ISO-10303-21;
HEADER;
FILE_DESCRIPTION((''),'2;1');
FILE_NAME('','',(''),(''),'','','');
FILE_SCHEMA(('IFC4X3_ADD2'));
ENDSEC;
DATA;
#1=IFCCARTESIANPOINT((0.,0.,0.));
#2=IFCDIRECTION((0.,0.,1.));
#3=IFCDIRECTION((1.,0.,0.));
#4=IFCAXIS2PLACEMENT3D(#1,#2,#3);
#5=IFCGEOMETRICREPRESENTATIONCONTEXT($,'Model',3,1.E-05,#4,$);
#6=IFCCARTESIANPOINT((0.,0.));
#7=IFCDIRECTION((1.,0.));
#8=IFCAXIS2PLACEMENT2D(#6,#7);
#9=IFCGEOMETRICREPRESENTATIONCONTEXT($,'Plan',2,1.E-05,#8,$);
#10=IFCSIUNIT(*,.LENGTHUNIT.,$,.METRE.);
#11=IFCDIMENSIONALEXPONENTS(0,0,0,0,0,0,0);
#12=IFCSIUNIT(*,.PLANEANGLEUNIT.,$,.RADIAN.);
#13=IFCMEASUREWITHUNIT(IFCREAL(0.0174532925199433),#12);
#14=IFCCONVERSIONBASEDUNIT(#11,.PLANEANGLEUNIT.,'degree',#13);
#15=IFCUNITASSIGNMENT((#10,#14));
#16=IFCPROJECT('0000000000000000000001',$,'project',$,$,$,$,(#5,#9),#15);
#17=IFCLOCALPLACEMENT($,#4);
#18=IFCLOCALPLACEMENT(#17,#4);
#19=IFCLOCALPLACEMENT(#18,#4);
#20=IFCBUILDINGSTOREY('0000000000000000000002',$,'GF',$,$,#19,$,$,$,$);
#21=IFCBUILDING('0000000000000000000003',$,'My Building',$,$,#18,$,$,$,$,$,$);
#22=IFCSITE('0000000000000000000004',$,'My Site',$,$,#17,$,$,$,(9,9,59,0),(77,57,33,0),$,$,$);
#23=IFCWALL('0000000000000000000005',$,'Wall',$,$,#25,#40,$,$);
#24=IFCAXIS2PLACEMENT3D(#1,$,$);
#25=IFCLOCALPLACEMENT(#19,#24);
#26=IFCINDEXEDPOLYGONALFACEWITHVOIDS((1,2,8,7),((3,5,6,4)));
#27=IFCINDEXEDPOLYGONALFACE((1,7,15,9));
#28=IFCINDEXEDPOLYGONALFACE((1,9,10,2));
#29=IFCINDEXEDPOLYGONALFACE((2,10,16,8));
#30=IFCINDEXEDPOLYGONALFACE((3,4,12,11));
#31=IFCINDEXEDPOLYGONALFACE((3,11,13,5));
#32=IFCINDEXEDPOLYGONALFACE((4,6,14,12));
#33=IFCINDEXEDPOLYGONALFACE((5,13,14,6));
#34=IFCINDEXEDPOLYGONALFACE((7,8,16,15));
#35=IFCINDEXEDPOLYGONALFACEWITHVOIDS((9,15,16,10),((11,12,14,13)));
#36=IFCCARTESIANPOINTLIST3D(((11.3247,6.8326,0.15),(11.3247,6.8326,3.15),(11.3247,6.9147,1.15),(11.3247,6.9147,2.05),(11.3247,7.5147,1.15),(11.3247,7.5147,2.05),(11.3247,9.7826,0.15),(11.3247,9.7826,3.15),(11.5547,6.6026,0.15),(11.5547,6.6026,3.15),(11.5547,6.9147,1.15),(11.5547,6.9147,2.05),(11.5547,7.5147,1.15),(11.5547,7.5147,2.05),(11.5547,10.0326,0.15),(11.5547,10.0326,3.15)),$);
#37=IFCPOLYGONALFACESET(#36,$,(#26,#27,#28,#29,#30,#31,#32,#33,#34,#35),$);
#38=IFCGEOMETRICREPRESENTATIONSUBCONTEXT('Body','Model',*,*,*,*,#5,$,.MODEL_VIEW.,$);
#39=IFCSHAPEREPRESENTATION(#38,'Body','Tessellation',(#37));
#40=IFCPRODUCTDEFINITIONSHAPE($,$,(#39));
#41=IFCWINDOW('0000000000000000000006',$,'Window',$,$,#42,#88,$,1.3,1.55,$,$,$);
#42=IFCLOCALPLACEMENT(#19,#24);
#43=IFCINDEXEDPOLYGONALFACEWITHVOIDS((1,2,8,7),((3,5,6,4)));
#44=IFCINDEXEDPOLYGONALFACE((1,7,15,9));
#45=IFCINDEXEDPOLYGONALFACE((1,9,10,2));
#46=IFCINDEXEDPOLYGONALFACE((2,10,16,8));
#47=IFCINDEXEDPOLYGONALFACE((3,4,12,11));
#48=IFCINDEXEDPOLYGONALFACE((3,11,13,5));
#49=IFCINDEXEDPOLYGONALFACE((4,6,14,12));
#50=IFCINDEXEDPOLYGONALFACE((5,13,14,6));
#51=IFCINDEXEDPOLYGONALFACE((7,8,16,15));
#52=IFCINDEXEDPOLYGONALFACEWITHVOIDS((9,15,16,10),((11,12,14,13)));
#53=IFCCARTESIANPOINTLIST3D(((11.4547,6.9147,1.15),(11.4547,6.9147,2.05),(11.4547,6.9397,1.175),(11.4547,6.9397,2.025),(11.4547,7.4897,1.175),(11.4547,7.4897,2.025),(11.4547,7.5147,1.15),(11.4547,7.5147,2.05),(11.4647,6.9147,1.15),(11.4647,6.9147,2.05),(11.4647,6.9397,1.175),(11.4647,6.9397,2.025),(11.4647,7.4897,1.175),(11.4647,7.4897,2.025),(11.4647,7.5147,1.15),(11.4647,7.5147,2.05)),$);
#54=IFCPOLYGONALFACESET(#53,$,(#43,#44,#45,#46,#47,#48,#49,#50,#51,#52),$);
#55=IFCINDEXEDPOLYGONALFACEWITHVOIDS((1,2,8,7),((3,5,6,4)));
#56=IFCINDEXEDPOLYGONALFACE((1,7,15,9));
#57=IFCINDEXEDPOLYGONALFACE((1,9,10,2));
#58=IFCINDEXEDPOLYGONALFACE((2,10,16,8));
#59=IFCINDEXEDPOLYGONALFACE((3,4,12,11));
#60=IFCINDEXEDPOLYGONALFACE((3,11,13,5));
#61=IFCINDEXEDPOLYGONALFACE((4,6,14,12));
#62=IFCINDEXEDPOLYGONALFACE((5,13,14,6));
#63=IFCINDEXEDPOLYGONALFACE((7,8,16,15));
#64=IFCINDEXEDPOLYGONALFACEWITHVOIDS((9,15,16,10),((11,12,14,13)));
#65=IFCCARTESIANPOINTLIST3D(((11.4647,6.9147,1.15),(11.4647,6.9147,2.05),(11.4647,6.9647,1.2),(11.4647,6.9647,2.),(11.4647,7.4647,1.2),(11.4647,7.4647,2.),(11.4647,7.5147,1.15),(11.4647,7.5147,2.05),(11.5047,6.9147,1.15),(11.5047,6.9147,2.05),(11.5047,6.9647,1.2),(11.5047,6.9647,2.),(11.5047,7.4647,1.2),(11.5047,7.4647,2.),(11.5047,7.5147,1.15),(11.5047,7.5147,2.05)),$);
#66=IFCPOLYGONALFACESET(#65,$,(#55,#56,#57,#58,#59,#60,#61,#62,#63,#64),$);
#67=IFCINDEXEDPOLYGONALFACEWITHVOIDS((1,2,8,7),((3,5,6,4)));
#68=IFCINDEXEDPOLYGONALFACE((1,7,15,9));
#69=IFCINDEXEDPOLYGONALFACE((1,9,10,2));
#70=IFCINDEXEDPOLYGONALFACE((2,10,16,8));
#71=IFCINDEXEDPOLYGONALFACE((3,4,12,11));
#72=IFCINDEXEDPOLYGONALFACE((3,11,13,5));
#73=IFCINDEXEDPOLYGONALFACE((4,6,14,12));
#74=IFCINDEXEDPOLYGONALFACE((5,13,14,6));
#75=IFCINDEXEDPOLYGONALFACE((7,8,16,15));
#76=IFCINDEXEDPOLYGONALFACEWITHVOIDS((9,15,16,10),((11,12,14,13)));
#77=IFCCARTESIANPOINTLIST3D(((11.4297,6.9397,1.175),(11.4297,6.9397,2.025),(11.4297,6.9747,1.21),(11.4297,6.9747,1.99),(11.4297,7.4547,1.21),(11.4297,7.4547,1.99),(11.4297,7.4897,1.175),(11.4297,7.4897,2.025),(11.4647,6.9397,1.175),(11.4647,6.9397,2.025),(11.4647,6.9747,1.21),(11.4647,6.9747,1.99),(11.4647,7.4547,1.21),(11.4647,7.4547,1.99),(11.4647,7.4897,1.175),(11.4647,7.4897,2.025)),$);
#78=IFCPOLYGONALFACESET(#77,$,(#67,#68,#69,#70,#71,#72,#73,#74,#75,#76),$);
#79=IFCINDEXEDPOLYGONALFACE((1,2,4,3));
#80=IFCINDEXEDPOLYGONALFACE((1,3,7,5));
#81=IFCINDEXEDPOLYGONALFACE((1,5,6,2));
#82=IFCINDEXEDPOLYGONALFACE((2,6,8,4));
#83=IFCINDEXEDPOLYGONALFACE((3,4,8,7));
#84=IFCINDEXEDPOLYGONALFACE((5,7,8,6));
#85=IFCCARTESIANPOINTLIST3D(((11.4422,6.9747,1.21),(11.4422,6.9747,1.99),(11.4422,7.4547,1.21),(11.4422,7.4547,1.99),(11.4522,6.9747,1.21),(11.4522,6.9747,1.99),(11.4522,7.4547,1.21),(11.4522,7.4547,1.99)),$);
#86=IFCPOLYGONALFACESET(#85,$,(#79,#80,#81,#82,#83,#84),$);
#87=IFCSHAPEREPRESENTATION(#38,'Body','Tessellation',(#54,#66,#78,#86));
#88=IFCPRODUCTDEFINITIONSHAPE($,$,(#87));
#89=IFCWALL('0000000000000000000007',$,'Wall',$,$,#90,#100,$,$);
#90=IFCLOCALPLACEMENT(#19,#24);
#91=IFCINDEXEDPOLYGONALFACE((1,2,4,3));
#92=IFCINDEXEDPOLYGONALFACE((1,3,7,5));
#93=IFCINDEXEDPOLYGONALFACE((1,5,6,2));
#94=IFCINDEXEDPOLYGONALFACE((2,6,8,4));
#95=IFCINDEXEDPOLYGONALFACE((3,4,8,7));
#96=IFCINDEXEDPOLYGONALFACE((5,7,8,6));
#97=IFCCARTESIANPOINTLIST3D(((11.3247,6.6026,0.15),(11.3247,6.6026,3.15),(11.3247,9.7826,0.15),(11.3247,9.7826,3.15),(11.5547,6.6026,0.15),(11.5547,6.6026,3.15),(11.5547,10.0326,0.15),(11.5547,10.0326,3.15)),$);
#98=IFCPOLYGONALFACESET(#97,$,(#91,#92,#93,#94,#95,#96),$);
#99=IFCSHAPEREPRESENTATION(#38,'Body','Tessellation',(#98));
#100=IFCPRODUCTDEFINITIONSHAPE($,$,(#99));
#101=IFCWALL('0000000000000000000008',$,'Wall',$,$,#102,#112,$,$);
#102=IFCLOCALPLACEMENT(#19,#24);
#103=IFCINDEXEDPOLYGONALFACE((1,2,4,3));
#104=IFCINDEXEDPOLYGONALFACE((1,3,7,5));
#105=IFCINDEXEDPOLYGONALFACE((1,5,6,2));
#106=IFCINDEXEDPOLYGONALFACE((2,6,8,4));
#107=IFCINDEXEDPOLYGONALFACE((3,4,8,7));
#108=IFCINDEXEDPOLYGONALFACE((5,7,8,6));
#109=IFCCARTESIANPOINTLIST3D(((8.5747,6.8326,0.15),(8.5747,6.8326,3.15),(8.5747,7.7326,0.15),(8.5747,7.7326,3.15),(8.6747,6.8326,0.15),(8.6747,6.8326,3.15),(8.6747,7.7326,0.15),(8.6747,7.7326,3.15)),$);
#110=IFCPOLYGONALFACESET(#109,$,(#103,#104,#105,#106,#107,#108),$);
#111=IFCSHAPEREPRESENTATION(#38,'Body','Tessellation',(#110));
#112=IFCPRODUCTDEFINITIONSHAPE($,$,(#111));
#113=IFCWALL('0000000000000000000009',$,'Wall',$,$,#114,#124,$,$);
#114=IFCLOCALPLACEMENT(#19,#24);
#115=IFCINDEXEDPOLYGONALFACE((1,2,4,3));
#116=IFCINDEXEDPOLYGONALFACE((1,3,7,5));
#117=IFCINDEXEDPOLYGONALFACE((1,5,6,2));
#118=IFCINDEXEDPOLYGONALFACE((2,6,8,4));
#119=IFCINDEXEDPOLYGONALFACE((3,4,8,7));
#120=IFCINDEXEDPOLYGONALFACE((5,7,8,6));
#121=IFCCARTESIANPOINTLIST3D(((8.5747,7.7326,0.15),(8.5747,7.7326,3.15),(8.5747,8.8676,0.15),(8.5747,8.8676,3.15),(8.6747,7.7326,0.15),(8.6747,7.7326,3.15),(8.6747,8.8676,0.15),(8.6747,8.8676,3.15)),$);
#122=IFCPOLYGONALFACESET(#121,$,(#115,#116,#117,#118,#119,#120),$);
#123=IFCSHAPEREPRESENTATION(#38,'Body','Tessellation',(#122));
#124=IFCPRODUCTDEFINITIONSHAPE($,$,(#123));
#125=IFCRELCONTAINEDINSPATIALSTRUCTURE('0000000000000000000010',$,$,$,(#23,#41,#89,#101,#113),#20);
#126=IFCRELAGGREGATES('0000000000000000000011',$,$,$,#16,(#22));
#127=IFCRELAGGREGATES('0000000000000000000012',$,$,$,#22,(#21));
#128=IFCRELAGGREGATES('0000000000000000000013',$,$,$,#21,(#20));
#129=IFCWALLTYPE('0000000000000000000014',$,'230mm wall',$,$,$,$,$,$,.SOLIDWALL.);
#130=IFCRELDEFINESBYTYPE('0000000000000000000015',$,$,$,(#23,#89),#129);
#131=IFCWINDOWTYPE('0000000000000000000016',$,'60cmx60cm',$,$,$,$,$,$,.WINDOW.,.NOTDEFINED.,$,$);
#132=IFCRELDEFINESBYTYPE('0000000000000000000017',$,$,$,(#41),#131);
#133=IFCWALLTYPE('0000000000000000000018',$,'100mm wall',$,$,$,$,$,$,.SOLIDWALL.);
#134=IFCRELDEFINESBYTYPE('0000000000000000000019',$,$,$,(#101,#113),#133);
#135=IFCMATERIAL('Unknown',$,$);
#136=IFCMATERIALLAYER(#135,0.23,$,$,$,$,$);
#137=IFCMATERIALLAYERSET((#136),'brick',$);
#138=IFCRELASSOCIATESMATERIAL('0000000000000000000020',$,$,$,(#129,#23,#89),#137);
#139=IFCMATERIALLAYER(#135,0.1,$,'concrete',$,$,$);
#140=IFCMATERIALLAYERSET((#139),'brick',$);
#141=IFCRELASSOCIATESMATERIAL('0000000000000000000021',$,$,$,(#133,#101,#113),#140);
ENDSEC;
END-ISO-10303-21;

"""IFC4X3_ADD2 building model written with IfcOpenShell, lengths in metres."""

from ifc_helpers import new_model, entity, si_unit, converted_unit, frame, origin_with_axes, origin_2d_with_axis, place, context, subcontext, project, spatial, line, indexed_curve, outline, extrude, shape, source, transform, mapped, material, layer, layer_set, layer_usage, type_object, type_shapes, element, fill, save


model = new_model("IFC4X3_ADD2")

# Units and contexts
model_context = context("Model", 3, precision=1e-05, world=origin_with_axes())
plan_context = context("Plan", 2, precision=1e-05, world=origin_2d_with_axis())
body_context_1 = subcontext(model_context, "Body", "Model", "MODEL_VIEW")
body_context_2 = subcontext(plan_context, "Body", "Plan", "PLAN_VIEW")
ifc_project = project(units=[si_unit("LENGTHUNIT", "METRE"), converted_unit("PLANEANGLEUNIT", "degree", entity("IfcReal", 0.0174532925199433), si_unit("PLANEANGLEUNIT", "RADIAN"), dimensions=[0, 0, 0, 0, 0, 0, 0])], contexts=[model_context, plan_context])

# Site, building, storey
site_placement = place(None, origin_with_axes())
site = spatial("IfcSite", under=ifc_project, at=site_placement, Name="My Site", RefLatitude=(9, 9, 59, 0), RefLongitude=(77, 57, 33, 0))
building_placement = place(site_placement, origin_with_axes())
building = spatial("IfcBuilding", under=site, at=building_placement, Name="My Building")
storey_placement = place(building_placement, origin_with_axes())
storey = spatial("IfcBuildingStorey", under=building, at=storey_placement, Name="GF")

# Shared definitions
ifc_material = material(Name="Unknown")
shared_shape_1 = source(origin_with_axes(), body_context_1, "Body", "SweptSolid", [
    extrude(outline(indexed_curve([(0.0, 0.0), (0.6, 0.0), (0.6, 0.9), (0.0, 0.9)], segments=[line(1, 2, 3, 4, 1)])), frame((0.0, -0.6, 0.0), z_axis=(0.0, -1.0, 0.0), x_axis=(1.0, 0.0, 0.0)), (0.0, 0.0, -1.0), 1.2),
])
window_type_1 = type_object("IfcWindowType", Name="60cmx60cm", PartitioningType="NOTDEFINED", PredefinedType="WINDOW")
shared_shape_2 = source(origin_with_axes(), body_context_1, "Body", "SweptSolid", [
    extrude(outline(indexed_curve([(0.0, 0.0), (0.6, 0.0), (0.6, 0.9), (0.0, 0.9)], segments=[line(1, 2, 3, 4, 1)]), holes=[indexed_curve([(0.025, 0.025), (0.575, 0.025), (0.575, 0.875), (0.025, 0.875)], segments=[line(1, 2, 3, 4, 1)])]), frame((0.0, 0.09, 0.0), z_axis=(0.0, -1.0, 0.0), x_axis=(1.0, 0.0, 0.0)), (0.0, 0.0, -1.0), 0.01),
    extrude(outline(indexed_curve([(0.0, 0.0), (0.6, 0.0), (0.6, 0.9), (0.0, 0.9)], segments=[line(1, 2, 3, 4, 1)]), holes=[indexed_curve([(0.05, 0.05), (0.55, 0.05), (0.55, 0.85), (0.05, 0.85)], segments=[line(1, 2, 3, 4, 1)])]), frame((0.0, 0.05, 0.0), z_axis=(0.0, -1.0, 0.0), x_axis=(1.0, 0.0, 0.0)), (0.0, 0.0, -1.0), 0.04),
    extrude(outline(indexed_curve([(0.0, 0.0), (0.55, 0.0), (0.55, 0.85), (0.0, 0.85)], segments=[line(1, 2, 3, 4, 1)]), holes=[indexed_curve([(0.035, 0.035), (0.515, 0.035), (0.515, 0.815), (0.035, 0.815)], segments=[line(1, 2, 3, 4, 1)])]), frame((0.025, 0.09, 0.025), z_axis=(0.0, -1.0, 0.0), x_axis=(1.0, 0.0, 0.0)), (0.0, 0.0, -1.0), 0.035),
    extrude(outline(indexed_curve([(0.035, 0.035), (0.515, 0.035), (0.515, 0.815), (0.035, 0.815)], segments=[line(1, 2, 3, 4, 1)])), frame((0.025, 0.1025, 0.025), z_axis=(0.0, -1.0, 0.0), x_axis=(1.0, 0.0, 0.0)), (0.0, 0.0, -1.0), 0.01),
])
shared_shape_3 = source(origin_with_axes(), body_context_2, "Body", "Curve2D", [
    entity("IfcIndexedPolyCurve", entity("IfcCartesianPointList2D", [[0.05, 0.05], [0.55, 0.05]])),
    entity("IfcIndexedPolyCurve", entity("IfcCartesianPointList2D", [[0.0, 0.1], [0.025, 0.1], [0.025, 0.09], [0.05, 0.09], [0.05, 0.05], [0.0, 0.05]]), [entity("IfcLineIndex", [1, 2, 3, 4, 5, 6, 1])]),
    entity("IfcIndexedPolyCurve", entity("IfcCartesianPointList2D", [[0.6, 0.1], [0.575, 0.1], [0.575, 0.09], [0.55, 0.09], [0.55, 0.05], [0.6, 0.05]]), [entity("IfcLineIndex", [1, 2, 3, 4, 5, 6, 1])]),
    entity("IfcIndexedPolyCurve", entity("IfcCartesianPointList2D", [[0.025, 0.09], [0.06, 0.09], [0.06, 0.125], [0.025, 0.125]]), [entity("IfcLineIndex", [1, 2, 3, 4, 1])]),
    entity("IfcIndexedPolyCurve", entity("IfcCartesianPointList2D", [[0.575, 0.09], [0.54, 0.09], [0.54, 0.125], [0.575, 0.125]]), [entity("IfcLineIndex", [1, 2, 3, 4, 1])]),
    entity("IfcIndexedPolyCurve", entity("IfcCartesianPointList2D", [[0.06, 0.09], [0.54, 0.09]])),
    entity("IfcIndexedPolyCurve", entity("IfcCartesianPointList2D", [[0.06, 0.125], [0.54, 0.125]])),
    entity("IfcIndexedPolyCurve", entity("IfcCartesianPointList2D", [[0.06, 0.1075], [0.54, 0.1075]])),
])
type_shapes(window_type_1, [shared_shape_2, shared_shape_3])

# Shared definitions
ifc_layer_1 = layer(ifc_material, 0.23)
ifc_layer_set_1 = layer_set([ifc_layer_1], Name="brick")
wall_type_1 = type_object("IfcWallType", Name="230mm wall", PredefinedType="SOLIDWALL", material=ifc_layer_set_1)

# Wall, opening, window
ifc_layer_usage_1 = layer_usage(ifc_layer_set_1, "AXIS2", "POSITIVE", 0.0)
wall_1_placement = place(storey_placement, frame((11.5547, 6.6026, 0.15), z_axis=(0.0, 0.0, 1.0), x_axis=(0.0, 1.0, 0.0)))
wall_1 = element("IfcWall", 1, at=wall_1_placement, inside=storey, type_object=wall_type_1, material=ifc_layer_usage_1, Name="Wall", context=body_context_1, shape_type="SweptSolid", body=[
    extrude(outline(indexed_curve([(0.0, 0.0), (0.23, 0.23), (3.18, 0.23), (3.43, 0.0)], segments=[line(1, 2, 3, 4, 1)])), origin_with_axes(), (0.0, 0.0, 1.0), 3.0),
])
opening_1_placement = place(wall_1_placement, frame((0.3121, 0.0, 1.0), z_axis=(0.0, 0.0, 1.0), x_axis=(1.0, 0.0, 0.0)))
opening_1 = element("IfcOpeningElement", 2, at=opening_1_placement, cuts=wall_1, PredefinedType="OPENING", context=body_context_1, shape_type="MappedRepresentation", body=[
    mapped(shared_shape_1, transform((0.0, 0.0, 0.0), x_axis=(1.0, 0.0, 0.0), y_axis=(0.0, 1.0, 0.0), z_axis=(0.0, 0.0, 1.0), scale=1.0)),
])
window_1_placement = place(opening_1_placement, frame((0.0, 0.0, 0.0), z_axis=(0.0, 0.0, 1.0), x_axis=(1.0, 0.0, 0.0)))
window_1 = element("IfcWindow", 3, at=window_1_placement, inside=storey, type_object=window_type_1, Name="Window", OverallHeight=1.3, OverallWidth=1.55, shapes=[
    shape(body_context_1, "Body", "MappedRepresentation", [mapped(shared_shape_2, transform((0.0, 0.0, 0.0), x_axis=(1.0, 0.0, 0.0), y_axis=(0.0, 1.0, 0.0), z_axis=(0.0, 0.0, 1.0), scale=1.0))]),
    shape(body_context_2, "Body", "MappedRepresentation", [mapped(shared_shape_3, transform((0.0, 0.0, 0.0), x_axis=(1.0, 0.0, 0.0), y_axis=(0.0, 1.0, 0.0), z_axis=(0.0, 0.0, 1.0), scale=1.0))]),
])
fill(opening_1, window_1)

# Walls
ifc_layer_usage_2 = layer_usage(ifc_layer_set_1, "AXIS2", "POSITIVE", 0.0)
wall_2_placement = place(storey_placement, frame((11.5547, 6.6026, 0.15), z_axis=(0.0, 0.0, 1.0), x_axis=(0.0, 1.0, 0.0)))
element("IfcWall", 4, at=wall_2_placement, inside=storey, type_object=wall_type_1, material=ifc_layer_usage_2, Name="Wall", context=body_context_1, shape_type="SweptSolid", body=[
    extrude(outline(indexed_curve([(0.0, 0.0), (0.0, 0.23), (3.18, 0.23), (3.43, 0.0)], segments=[line(1, 2, 3, 4, 1)])), origin_with_axes(), (0.0, 0.0, 1.0), 3.0),
])
ifc_layer_2 = layer(ifc_material, 0.1, Name="concrete")
ifc_layer_set_2 = layer_set([ifc_layer_2], Name="brick")
ifc_layer_usage_3 = layer_usage(ifc_layer_set_2, "AXIS2", "POSITIVE", 0.0)
wall_type_2 = type_object("IfcWallType", Name="100mm wall", PredefinedType="SOLIDWALL", material=ifc_layer_set_2)
wall_3_placement = place(storey_placement, frame((8.6747, 6.8326, 0.15), z_axis=(0.0, 0.0, 1.0), x_axis=(0.0, 1.0, 0.0)))
element("IfcWall", 5, at=wall_3_placement, inside=storey, type_object=wall_type_2, material=ifc_layer_usage_3, Name="Wall", context=body_context_1, shape_type="SweptSolid", body=[
    extrude(outline(indexed_curve([(0.0, 0.0), (0.0, 0.1), (0.9, 0.1), (0.9, 0.0)], segments=[line(1, 2, 3, 4, 1)])), origin_with_axes(), (0.0, 0.0, 1.0), 3.0),
])
ifc_layer_usage_4 = layer_usage(ifc_layer_set_2, "AXIS2", "POSITIVE", 0.0)
wall_4_placement = place(storey_placement, frame((8.6747, 7.7326, 0.15), z_axis=(0.0, 0.0, 1.0), x_axis=(0.0, 1.0, 0.0)))
element("IfcWall", 6, at=wall_4_placement, inside=storey, type_object=wall_type_2, material=ifc_layer_usage_4, Name="Wall", context=body_context_1, shape_type="SweptSolid", body=[
    extrude(outline(indexed_curve([(0.0, 0.0), (0.0, 0.1), (1.135, 0.1), (1.135, 0.0)], segments=[line(1, 2, 3, 4, 1)])), origin_with_axes(), (0.0, 0.0, 1.0), 3.0),
])

save(model, "model.ifc")
